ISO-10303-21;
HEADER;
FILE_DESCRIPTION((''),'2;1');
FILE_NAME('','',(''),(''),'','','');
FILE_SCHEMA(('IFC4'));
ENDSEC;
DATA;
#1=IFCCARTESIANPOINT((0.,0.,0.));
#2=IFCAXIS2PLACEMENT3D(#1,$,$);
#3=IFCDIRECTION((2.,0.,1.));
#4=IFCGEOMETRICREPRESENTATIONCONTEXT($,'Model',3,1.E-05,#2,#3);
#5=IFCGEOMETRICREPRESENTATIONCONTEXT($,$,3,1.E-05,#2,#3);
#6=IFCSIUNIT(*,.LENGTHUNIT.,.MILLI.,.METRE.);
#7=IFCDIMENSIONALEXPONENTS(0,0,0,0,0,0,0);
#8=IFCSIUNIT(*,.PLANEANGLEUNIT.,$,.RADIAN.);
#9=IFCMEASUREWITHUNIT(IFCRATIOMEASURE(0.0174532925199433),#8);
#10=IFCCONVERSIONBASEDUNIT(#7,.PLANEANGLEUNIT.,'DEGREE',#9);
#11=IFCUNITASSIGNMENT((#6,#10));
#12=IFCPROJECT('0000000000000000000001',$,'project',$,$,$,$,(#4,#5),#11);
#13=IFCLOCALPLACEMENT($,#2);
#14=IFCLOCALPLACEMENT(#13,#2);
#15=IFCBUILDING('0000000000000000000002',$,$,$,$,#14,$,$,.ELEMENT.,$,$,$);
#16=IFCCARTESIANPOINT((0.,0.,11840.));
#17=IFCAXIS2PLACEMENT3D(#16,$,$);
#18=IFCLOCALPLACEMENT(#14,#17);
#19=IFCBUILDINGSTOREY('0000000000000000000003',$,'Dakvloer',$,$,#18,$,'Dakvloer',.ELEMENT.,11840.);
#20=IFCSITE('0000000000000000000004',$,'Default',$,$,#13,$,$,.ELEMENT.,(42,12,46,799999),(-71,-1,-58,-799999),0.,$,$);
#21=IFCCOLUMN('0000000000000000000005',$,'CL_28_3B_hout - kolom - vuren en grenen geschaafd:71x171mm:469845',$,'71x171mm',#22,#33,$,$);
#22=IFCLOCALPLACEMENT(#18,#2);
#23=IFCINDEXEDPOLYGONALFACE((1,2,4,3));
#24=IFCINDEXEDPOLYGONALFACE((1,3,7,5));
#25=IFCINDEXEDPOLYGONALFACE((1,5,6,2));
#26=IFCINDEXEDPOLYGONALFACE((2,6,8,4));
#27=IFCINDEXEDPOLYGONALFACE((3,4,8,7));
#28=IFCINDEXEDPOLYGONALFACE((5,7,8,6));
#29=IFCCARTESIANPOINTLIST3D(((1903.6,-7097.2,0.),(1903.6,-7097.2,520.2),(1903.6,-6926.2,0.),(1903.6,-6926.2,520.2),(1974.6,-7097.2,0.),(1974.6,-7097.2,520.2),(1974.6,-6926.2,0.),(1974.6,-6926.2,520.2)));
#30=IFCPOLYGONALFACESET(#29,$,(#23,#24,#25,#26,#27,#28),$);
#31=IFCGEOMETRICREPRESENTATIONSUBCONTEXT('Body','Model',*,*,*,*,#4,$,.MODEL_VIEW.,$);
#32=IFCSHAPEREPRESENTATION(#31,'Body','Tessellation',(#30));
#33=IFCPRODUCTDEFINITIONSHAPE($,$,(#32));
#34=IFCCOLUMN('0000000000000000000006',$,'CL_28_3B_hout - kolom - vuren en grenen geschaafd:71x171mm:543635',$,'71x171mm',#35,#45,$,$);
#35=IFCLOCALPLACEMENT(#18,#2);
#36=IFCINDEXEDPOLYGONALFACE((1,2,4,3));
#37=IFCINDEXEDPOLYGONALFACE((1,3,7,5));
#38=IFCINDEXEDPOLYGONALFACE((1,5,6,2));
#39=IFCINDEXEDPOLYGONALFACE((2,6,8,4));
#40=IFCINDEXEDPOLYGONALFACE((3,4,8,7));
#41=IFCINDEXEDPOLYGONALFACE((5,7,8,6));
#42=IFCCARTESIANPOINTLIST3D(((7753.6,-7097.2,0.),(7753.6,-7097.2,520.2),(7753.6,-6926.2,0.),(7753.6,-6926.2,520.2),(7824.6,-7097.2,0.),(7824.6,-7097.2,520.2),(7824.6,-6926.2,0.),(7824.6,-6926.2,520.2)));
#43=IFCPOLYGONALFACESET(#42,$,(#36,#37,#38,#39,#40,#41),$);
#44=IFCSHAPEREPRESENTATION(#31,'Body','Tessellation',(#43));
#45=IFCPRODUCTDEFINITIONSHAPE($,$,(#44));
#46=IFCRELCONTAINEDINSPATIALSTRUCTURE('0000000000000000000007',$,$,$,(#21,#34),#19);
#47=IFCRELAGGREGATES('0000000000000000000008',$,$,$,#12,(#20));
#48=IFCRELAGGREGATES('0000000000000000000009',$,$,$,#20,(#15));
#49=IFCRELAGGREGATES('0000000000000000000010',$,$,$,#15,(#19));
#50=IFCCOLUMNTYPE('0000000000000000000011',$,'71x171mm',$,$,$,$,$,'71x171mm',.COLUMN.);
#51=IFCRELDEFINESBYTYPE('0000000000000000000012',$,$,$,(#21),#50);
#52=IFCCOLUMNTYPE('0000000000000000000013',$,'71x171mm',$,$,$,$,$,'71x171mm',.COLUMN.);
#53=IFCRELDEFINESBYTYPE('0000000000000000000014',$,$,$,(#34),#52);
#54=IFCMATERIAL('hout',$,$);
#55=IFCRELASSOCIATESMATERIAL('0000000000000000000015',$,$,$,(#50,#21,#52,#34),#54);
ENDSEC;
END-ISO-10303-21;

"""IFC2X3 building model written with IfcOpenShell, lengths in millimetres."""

from ifc_helpers import new_model, entity, si_unit, converted_unit, direction, frame, frame_2d, origin, place, context, subcontext, project, spatial, rectangle, extrude, source, transform, mapped, material, type_object, type_shapes, element, save


model = new_model("IFC2X3")

# Units and contexts
model_context = context("Model", 3, precision=1e-05, world=origin(), true_north=direction((2.0, 0.0, 1.0)))
context_of_model = context(None, 3, precision=1e-05, world=origin(), true_north=direction((2.0, 0.0, 1.0)))
body_context = subcontext(model_context, "Body", "Model", "MODEL_VIEW")
ifc_project = project(units=[si_unit("LENGTHUNIT", "METRE", prefix="MILLI"), converted_unit("PLANEANGLEUNIT", "DEGREE", entity("IfcRatioMeasure", 0.0174532925199433), si_unit("PLANEANGLEUNIT", "RADIAN"), dimensions=[0, 0, 0, 0, 0, 0, 0])], contexts=[model_context, context_of_model])

# Site, building, storey
site_placement = place(None, origin())
site = spatial("IfcSite", under=ifc_project, at=site_placement, Name="Default", CompositionType="ELEMENT", RefLatitude=(42, 12, 46, 799999), RefLongitude=(-71, -1, -58, -799999), RefElevation=0.0)
building_placement = place(site_placement, origin())
building = spatial("IfcBuilding", under=site, at=building_placement, CompositionType="ELEMENT")
storey_placement = place(building_placement, frame((0.0, 0.0, 11840.0)))
storey = spatial("IfcBuildingStorey", under=building, at=storey_placement, Name="Dakvloer", LongName="Dakvloer", CompositionType="ELEMENT", Elevation=11840.0)

# Columns
ifc_material = material(Name="hout")
column_type_1 = type_object("IfcColumnType", Name="71x171mm", ElementType="71x171mm", PredefinedType="COLUMN", material=ifc_material)
shared_shape_1 = source(origin(), body_context, "Body", "SweptSolid", [
    extrude(rectangle(XDim=171.0, YDim=71.0, at=frame_2d((1939.1, -7011.7), x_axis=(0.0, -1.0))), origin(), (0.0, 0.0, 1.0), 520.2),
])
type_shapes(column_type_1, [shared_shape_1])
column_1_placement = place(storey_placement, origin())
element("IfcColumn", 1, at=column_1_placement, inside=storey, type_object=column_type_1, material=ifc_material, Name="CL_28_3B_hout - kolom - vuren en grenen geschaafd:71x171mm:469845", ObjectType="71x171mm", context=body_context, shape_type="MappedRepresentation", body=[
    mapped(shared_shape_1, transform((0.0, 0.0, 0.0), scale=1.0)),
])
column_type_2 = type_object("IfcColumnType", Name="71x171mm", ElementType="71x171mm", PredefinedType="COLUMN", material=ifc_material)
shared_shape_2 = source(origin(), body_context, "Body", "SweptSolid", [
    extrude(rectangle(XDim=171.0, YDim=71.0, at=frame_2d((7789.1, -7011.7), x_axis=(0.0, -1.0))), origin(), (0.0, 0.0, 1.0), 520.2),
])
type_shapes(column_type_2, [shared_shape_2])
column_2_placement = place(storey_placement, origin())
element("IfcColumn", 2, at=column_2_placement, inside=storey, type_object=column_type_2, material=ifc_material, Name="CL_28_3B_hout - kolom - vuren en grenen geschaafd:71x171mm:543635", ObjectType="71x171mm", context=body_context, shape_type="MappedRepresentation", body=[
    mapped(shared_shape_2, transform((0.0, 0.0, 0.0), scale=1.0)),
])

save(model, "model.ifc")
